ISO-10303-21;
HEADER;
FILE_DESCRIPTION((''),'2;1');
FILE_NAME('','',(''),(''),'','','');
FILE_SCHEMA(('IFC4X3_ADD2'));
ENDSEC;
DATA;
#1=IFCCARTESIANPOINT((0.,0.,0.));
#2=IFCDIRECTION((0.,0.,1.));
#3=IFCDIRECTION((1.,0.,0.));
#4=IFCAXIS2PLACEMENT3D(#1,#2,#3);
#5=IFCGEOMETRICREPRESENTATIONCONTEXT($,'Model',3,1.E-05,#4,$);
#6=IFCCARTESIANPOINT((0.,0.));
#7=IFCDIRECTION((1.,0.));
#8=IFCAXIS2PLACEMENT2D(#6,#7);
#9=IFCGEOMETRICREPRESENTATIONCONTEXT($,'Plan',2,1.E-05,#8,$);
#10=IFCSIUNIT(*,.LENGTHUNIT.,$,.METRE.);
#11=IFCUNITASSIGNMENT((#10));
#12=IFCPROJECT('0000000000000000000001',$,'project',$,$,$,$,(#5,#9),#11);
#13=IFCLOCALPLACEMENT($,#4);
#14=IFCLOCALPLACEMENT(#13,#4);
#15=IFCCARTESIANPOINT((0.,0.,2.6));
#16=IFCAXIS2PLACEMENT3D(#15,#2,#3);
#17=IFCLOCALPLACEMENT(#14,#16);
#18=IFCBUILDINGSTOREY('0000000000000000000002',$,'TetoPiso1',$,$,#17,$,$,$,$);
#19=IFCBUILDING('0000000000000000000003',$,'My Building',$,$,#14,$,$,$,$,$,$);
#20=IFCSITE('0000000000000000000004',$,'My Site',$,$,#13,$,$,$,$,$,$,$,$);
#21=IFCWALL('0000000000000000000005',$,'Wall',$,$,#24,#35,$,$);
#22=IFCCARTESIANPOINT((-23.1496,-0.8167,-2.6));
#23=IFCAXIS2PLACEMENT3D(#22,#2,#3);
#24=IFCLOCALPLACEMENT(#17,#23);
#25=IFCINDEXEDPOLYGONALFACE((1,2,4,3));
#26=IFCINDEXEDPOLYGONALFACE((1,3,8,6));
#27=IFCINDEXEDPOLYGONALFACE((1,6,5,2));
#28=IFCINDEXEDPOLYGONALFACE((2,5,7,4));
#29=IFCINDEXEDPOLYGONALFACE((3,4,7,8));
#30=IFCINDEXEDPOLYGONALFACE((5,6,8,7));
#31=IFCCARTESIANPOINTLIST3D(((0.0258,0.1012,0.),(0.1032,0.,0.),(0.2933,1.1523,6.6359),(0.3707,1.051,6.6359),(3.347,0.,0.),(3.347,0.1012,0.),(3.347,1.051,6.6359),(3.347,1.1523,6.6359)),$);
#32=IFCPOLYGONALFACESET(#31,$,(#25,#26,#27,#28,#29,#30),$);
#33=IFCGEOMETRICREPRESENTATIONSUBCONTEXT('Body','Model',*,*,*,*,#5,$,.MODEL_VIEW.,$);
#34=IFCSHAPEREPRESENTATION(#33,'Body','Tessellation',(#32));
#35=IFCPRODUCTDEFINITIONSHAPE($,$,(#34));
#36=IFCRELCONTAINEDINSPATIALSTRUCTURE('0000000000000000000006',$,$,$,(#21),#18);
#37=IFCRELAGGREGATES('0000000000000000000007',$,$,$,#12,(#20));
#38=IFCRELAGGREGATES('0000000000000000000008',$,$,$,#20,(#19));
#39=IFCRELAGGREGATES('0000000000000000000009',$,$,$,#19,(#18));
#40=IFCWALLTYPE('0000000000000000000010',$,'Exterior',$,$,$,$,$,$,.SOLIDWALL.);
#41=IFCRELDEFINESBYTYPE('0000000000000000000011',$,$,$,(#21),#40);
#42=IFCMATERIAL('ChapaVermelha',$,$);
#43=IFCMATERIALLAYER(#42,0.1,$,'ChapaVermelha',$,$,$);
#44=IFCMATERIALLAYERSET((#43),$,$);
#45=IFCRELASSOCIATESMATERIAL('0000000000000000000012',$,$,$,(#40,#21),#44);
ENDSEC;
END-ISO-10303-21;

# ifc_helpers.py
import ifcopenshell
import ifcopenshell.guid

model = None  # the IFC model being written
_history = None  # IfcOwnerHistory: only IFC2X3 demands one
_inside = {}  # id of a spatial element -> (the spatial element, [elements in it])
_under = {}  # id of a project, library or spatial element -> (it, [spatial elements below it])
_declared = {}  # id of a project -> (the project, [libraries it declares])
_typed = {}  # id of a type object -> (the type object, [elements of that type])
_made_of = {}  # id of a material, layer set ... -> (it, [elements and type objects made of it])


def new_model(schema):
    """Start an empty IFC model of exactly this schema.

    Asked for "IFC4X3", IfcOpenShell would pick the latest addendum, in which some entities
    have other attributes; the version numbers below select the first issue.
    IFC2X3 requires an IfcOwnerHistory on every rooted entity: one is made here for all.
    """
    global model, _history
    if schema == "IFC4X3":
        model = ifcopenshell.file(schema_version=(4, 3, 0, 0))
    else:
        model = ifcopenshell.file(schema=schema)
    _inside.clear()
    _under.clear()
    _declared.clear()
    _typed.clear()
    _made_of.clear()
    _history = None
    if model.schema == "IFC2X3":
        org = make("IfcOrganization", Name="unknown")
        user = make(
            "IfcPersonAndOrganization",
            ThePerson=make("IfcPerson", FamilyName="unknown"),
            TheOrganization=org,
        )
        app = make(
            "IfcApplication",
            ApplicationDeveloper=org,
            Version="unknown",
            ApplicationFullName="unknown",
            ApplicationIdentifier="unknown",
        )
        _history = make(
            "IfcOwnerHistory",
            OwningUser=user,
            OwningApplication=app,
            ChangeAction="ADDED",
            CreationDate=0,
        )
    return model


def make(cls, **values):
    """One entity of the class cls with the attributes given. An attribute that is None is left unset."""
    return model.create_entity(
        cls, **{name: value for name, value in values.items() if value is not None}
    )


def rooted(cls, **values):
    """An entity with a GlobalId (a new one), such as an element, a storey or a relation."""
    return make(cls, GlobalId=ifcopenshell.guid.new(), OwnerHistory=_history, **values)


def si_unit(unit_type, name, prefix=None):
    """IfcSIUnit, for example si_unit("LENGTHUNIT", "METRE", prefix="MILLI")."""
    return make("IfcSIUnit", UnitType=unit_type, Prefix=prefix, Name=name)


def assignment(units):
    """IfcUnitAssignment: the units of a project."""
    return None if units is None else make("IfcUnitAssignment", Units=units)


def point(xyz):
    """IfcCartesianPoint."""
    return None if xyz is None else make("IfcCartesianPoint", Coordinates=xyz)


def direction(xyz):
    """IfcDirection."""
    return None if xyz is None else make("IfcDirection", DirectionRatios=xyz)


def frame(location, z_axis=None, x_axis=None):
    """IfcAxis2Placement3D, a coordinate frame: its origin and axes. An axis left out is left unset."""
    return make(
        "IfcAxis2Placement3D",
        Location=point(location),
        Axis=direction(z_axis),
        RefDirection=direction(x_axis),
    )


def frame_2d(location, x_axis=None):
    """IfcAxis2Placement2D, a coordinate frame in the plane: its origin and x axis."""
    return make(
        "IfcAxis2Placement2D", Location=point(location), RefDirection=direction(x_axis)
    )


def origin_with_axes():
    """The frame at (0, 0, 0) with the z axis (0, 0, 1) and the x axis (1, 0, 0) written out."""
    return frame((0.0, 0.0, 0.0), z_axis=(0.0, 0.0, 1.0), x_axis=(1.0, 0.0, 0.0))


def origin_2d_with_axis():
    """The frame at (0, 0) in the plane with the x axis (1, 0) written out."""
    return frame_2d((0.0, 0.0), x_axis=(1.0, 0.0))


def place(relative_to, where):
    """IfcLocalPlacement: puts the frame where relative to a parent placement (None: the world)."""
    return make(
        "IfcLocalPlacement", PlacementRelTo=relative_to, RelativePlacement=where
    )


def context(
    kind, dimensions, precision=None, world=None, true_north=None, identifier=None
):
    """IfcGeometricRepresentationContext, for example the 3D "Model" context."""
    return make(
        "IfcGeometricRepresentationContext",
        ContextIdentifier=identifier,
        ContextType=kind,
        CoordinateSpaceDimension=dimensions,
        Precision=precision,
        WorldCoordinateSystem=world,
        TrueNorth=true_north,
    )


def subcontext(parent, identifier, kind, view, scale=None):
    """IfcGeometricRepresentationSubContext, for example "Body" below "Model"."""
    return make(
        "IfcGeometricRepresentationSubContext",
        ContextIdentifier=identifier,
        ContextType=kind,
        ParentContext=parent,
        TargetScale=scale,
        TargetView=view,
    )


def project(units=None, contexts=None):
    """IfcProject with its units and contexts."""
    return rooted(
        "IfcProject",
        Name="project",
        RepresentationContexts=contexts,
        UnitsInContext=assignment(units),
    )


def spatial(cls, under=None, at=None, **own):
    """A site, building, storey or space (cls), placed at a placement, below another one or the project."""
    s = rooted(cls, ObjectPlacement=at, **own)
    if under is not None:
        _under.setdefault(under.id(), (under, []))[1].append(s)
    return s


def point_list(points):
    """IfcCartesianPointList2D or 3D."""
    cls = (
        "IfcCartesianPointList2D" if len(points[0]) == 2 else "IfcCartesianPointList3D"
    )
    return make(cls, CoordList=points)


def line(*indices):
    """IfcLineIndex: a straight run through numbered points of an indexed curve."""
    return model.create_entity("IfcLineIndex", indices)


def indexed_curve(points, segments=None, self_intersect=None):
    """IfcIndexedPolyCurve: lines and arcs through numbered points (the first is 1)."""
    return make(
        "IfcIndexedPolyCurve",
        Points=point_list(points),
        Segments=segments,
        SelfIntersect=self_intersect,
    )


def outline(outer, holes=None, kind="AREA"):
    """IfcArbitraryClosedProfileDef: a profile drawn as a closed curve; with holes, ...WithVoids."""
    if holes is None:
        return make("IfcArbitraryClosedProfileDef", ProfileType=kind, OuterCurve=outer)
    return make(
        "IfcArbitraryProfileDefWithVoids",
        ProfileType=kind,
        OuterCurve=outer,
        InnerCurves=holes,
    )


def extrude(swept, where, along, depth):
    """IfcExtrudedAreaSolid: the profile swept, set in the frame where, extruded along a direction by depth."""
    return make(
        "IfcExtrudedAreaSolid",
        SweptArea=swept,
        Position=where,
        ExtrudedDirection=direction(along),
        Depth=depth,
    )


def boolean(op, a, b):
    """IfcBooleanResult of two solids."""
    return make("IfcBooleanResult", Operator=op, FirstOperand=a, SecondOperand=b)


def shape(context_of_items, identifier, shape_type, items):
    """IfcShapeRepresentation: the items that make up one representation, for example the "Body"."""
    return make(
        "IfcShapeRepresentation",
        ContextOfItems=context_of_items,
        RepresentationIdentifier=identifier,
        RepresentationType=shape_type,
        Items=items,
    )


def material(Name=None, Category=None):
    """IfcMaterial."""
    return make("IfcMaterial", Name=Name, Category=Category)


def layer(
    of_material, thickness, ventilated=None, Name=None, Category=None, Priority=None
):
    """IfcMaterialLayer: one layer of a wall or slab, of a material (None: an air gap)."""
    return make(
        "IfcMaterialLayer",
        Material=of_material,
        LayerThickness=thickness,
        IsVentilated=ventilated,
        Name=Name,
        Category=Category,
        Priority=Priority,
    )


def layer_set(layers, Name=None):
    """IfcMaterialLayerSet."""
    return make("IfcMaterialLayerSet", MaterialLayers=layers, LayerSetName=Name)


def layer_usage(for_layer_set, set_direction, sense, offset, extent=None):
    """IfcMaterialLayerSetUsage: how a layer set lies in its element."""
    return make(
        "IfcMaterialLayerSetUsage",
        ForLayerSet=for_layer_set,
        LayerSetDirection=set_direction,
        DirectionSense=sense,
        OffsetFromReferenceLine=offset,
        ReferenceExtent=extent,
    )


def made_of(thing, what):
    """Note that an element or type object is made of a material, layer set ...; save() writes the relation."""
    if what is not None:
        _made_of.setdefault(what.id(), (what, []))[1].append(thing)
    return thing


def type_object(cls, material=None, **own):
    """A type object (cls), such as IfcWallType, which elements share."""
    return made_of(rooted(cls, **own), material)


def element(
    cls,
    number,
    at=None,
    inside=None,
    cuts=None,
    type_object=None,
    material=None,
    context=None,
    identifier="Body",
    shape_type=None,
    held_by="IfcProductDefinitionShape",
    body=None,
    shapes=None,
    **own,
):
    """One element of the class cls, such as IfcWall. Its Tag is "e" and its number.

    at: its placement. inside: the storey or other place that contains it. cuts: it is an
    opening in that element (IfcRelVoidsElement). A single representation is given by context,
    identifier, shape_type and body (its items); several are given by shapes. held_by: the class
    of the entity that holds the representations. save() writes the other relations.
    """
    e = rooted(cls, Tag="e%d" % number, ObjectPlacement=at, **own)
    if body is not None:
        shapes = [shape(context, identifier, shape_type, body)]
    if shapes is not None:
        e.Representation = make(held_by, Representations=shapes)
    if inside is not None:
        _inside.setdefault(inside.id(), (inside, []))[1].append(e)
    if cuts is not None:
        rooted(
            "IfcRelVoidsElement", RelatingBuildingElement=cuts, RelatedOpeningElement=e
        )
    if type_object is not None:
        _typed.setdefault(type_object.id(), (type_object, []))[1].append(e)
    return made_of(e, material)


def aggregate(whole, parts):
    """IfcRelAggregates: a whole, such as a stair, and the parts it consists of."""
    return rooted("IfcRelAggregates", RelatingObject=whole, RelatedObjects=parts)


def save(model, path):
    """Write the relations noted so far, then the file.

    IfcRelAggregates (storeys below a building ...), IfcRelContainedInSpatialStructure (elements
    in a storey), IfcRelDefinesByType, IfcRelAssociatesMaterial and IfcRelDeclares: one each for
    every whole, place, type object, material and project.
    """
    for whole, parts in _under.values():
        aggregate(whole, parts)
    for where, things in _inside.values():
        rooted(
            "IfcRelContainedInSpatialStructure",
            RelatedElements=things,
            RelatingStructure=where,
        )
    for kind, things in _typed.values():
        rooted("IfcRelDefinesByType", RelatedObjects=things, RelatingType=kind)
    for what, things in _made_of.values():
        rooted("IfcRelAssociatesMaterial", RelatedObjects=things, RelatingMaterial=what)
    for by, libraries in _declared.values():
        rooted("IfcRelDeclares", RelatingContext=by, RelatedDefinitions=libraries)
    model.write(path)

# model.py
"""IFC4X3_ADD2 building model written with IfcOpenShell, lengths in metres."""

from ifc_helpers import new_model, si_unit, frame, origin_with_axes, origin_2d_with_axis, place, context, subcontext, project, spatial, line, indexed_curve, outline, extrude, boolean, material, layer, layer_set, layer_usage, type_object, element, save


model = new_model("IFC4X3_ADD2")

# Units and contexts
model_context = context("Model", 3, precision=1e-05, world=origin_with_axes())
plan_context = context("Plan", 2, precision=1e-05, world=origin_2d_with_axis())
body_context = subcontext(model_context, "Body", "Model", "MODEL_VIEW")
ifc_project = project(units=[si_unit("LENGTHUNIT", "METRE")], contexts=[model_context, plan_context])

# Site, building, storey
site_placement = place(None, origin_with_axes())
site = spatial("IfcSite", under=ifc_project, at=site_placement, Name="My Site")
building_placement = place(site_placement, origin_with_axes())
building = spatial("IfcBuilding", under=site, at=building_placement, Name="My Building")
storey_placement = place(building_placement, frame((0.0, 0.0, 2.6), z_axis=(0.0, 0.0, 1.0), x_axis=(1.0, 0.0, 0.0)))
storey = spatial("IfcBuildingStorey", under=building, at=storey_placement, Name="TetoPiso1")

# Wall
ifc_material_1 = material(Name="ChapaVermelha")
ifc_layer_1 = layer(ifc_material_1, 0.1, Name="ChapaVermelha")
ifc_layer_set_1 = layer_set([ifc_layer_1])
ifc_layer_usage_1 = layer_usage(ifc_layer_set_1, "AXIS2", "POSITIVE", 0.0)
wall_type_1 = type_object("IfcWallType", Name="Exterior", PredefinedType="SOLIDWALL", material=ifc_layer_set_1)
wall_1_placement = place(storey_placement, frame((-23.1496, -0.8167, -2.6), z_axis=(0.0, 0.0, 1.0), x_axis=(1.0, 0.0, 0.0)))
element("IfcWall", 1, at=wall_1_placement, inside=storey, type_object=wall_type_1, material=ifc_layer_usage_1, Name="Wall", context=body_context, shape_type="CSG", body=[
    boolean("DIFFERENCE", extrude(outline(indexed_curve([(0.1032, 0.0), (0.0258, 0.1012), (3.347, 0.1012), (3.347, 0.0)], segments=[line(1, 2, 3, 4, 1)])), origin_with_axes(), (0.0, 0.156434, 0.987688), 6.7186), extrude(outline(indexed_curve([(0.1032, 0.0), (0.0258, 0.1012), (-0.2417, 0.1012), (-0.2417, 0.0)], segments=[line(1, 2, 3, 4, 1)])), origin_with_axes(), (0.038586, 0.151601, 0.95717), 6.7239)),
])

save(model, "model.ifc")
